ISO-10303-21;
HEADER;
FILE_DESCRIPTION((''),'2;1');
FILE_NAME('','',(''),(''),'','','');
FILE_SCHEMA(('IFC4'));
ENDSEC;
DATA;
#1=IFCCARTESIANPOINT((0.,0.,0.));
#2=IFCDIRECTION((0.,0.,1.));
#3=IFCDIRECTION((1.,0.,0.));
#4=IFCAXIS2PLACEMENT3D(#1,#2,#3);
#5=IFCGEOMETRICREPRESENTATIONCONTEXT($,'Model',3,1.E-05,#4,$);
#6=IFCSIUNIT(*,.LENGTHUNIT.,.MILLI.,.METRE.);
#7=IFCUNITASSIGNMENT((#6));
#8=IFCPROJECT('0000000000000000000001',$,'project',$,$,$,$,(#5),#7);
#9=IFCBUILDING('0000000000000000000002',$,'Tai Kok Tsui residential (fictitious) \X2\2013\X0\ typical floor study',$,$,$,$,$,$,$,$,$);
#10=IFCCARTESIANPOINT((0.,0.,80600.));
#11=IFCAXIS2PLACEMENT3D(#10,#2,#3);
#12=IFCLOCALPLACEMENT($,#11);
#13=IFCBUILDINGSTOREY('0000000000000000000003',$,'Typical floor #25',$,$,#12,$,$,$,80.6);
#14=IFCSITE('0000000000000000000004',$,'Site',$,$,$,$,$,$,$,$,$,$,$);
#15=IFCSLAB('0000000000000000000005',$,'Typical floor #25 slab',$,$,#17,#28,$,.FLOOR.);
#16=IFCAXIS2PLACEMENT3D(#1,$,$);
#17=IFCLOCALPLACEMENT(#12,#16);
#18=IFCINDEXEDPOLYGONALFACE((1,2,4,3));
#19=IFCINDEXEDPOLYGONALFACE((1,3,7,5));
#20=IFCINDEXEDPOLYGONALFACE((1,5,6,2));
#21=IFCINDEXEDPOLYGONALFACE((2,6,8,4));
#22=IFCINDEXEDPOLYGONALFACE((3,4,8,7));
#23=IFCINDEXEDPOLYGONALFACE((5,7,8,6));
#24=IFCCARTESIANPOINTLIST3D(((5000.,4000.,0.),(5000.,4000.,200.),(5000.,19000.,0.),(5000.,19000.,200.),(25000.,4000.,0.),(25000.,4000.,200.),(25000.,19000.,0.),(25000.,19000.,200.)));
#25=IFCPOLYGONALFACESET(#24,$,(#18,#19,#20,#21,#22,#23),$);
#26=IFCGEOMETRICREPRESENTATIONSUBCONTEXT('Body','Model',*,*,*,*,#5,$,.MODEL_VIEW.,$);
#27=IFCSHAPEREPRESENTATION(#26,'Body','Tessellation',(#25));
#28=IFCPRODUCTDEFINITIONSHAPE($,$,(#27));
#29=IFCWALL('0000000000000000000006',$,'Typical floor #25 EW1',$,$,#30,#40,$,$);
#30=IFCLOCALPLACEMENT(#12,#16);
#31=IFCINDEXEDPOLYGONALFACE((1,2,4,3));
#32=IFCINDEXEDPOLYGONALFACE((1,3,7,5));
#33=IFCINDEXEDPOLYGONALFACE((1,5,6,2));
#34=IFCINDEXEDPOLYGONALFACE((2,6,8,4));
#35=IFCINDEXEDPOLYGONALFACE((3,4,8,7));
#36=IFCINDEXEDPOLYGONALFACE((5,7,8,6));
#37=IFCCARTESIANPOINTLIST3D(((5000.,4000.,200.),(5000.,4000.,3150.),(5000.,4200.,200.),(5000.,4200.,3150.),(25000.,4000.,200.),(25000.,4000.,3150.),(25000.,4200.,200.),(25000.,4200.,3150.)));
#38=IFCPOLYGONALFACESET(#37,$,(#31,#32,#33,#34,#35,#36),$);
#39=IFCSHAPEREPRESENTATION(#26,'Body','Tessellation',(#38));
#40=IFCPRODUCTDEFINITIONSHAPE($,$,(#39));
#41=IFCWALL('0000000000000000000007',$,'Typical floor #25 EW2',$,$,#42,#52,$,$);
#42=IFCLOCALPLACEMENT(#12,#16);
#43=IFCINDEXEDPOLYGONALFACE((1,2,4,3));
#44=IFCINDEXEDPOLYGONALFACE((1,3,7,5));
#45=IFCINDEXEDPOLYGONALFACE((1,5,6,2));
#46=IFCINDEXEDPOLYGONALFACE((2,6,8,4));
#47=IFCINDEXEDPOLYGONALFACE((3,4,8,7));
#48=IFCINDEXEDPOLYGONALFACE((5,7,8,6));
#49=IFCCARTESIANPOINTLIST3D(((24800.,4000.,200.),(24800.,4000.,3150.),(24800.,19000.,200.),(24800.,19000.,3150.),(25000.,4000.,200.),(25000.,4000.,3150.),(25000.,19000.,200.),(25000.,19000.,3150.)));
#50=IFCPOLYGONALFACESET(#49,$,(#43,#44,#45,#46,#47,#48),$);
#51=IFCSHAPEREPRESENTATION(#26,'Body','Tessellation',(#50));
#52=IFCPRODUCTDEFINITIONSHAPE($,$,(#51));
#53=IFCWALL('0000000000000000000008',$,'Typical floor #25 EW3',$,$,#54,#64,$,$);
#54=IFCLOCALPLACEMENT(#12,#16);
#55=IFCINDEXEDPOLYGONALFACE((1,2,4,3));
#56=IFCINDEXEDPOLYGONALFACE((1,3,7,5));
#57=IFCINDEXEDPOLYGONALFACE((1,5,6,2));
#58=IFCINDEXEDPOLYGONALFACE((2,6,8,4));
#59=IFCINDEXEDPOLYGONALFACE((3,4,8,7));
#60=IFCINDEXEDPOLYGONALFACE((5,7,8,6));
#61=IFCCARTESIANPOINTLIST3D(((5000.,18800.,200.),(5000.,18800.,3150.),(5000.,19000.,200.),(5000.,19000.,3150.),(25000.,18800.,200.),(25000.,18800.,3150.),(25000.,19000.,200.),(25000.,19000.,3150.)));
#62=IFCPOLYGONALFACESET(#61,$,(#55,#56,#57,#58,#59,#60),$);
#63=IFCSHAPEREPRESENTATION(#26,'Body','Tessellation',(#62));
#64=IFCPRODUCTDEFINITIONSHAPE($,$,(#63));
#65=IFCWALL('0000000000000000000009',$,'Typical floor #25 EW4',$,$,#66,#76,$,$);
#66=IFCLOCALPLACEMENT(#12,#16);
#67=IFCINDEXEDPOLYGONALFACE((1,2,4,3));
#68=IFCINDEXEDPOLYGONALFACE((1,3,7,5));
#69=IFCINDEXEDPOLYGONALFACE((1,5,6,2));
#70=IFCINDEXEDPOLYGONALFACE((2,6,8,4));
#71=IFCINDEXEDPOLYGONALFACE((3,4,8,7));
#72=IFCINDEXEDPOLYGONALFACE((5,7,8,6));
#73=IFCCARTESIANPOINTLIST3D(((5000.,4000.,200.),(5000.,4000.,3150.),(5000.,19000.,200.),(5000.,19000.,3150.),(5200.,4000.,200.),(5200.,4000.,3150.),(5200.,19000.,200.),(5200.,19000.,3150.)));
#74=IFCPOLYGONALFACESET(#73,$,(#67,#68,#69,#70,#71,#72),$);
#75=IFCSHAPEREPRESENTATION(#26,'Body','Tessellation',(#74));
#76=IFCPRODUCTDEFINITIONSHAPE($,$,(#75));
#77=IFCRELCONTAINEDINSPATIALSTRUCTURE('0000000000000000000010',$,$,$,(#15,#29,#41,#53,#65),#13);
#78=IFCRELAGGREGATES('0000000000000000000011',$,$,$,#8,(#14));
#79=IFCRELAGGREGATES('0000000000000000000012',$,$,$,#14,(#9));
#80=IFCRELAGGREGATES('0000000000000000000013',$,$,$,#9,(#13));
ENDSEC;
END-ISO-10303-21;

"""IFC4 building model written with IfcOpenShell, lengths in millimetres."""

from ifc_helpers import new_model, si_unit, frame, origin_with_axes, place, context, subcontext, project, spatial, indexed_curve, outline, extrude, element, save


model = new_model("IFC4")

# Units and contexts
model_context = context("Model", 3, precision=1e-05, world=origin_with_axes())
body_context = subcontext(model_context, "Body", "Model", "MODEL_VIEW")
ifc_project = project(units=[si_unit("LENGTHUNIT", "METRE", prefix="MILLI")], contexts=[model_context])

# Site, building, storey
site = spatial("IfcSite", under=ifc_project, Name="Site")
building = spatial("IfcBuilding", under=site, Name="Tai Kok Tsui residential (fictitious) – typical floor study")
storey_placement = place(None, frame((0.0, 0.0, 80600.0), z_axis=(0.0, 0.0, 1.0), x_axis=(1.0, 0.0, 0.0)))
storey = spatial("IfcBuildingStorey", under=building, at=storey_placement, Name="Typical floor #25", Elevation=80.6)

# Slab
slab_placement = place(storey_placement, origin_with_axes())
element("IfcSlab", 1, at=slab_placement, inside=storey, Name="Typical floor #25 slab", PredefinedType="FLOOR", context=body_context, shape_type="SweptSolid", body=[
    extrude(outline(indexed_curve([(5000.0, 4000.0), (25000.0, 4000.0), (25000.0, 19000.0), (5000.0, 19000.0)])), None, (0.0, 0.0, 1.0), 200.0),
])

# Walls
wall_1_placement = place(storey_placement, frame((5000.0, 4000.0, 200.0), z_axis=(0.0, 0.0, 1.0), x_axis=(1.0, 0.0, 0.0)))
element("IfcWall", 2, at=wall_1_placement, inside=storey, Name="Typical floor #25 EW1", context=body_context, shape_type="SweptSolid", body=[
    extrude(outline(indexed_curve([(0.0, 0.0), (0.0, 200.0), (20000.0, 200.0), (20000.0, 0.0), (0.0, 0.0)], self_intersect=False)), origin_with_axes(), (0.0, 0.0, 1.0), 2950.0),
])
wall_2_placement = place(storey_placement, frame((25000.0, 4000.0, 200.0), z_axis=(0.0, 0.0, 1.0), x_axis=(0.0, 1.0, 0.0)))
element("IfcWall", 3, at=wall_2_placement, inside=storey, Name="Typical floor #25 EW2", context=body_context, shape_type="SweptSolid", body=[
    extrude(outline(indexed_curve([(0.0, 0.0), (0.0, 200.0), (15000.0, 200.0), (15000.0, 0.0), (0.0, 0.0)], self_intersect=False)), origin_with_axes(), (0.0, 0.0, 1.0), 2950.0),
])
wall_3_placement = place(storey_placement, frame((25000.0, 19000.0, 200.0), z_axis=(0.0, 0.0, 1.0), x_axis=(-1.0, 0.0, 0.0)))
element("IfcWall", 4, at=wall_3_placement, inside=storey, Name="Typical floor #25 EW3", context=body_context, shape_type="SweptSolid", body=[
    extrude(outline(indexed_curve([(0.0, 0.0), (0.0, 200.0), (20000.0, 200.0), (20000.0, 0.0), (0.0, 0.0)], self_intersect=False)), origin_with_axes(), (0.0, 0.0, 1.0), 2950.0),
])
wall_4_placement = place(storey_placement, frame((5000.0, 19000.0, 200.0), z_axis=(0.0, 0.0, 1.0), x_axis=(0.0, -1.0, 0.0)))
element("IfcWall", 5, at=wall_4_placement, inside=storey, Name="Typical floor #25 EW4", context=body_context, shape_type="SweptSolid", body=[
    extrude(outline(indexed_curve([(0.0, 0.0), (0.0, 200.0), (15000.0, 200.0), (15000.0, 0.0), (0.0, 0.0)], self_intersect=False)), origin_with_axes(), (0.0, 0.0, 1.0), 2950.0),
])

save(model, "model.ifc")
